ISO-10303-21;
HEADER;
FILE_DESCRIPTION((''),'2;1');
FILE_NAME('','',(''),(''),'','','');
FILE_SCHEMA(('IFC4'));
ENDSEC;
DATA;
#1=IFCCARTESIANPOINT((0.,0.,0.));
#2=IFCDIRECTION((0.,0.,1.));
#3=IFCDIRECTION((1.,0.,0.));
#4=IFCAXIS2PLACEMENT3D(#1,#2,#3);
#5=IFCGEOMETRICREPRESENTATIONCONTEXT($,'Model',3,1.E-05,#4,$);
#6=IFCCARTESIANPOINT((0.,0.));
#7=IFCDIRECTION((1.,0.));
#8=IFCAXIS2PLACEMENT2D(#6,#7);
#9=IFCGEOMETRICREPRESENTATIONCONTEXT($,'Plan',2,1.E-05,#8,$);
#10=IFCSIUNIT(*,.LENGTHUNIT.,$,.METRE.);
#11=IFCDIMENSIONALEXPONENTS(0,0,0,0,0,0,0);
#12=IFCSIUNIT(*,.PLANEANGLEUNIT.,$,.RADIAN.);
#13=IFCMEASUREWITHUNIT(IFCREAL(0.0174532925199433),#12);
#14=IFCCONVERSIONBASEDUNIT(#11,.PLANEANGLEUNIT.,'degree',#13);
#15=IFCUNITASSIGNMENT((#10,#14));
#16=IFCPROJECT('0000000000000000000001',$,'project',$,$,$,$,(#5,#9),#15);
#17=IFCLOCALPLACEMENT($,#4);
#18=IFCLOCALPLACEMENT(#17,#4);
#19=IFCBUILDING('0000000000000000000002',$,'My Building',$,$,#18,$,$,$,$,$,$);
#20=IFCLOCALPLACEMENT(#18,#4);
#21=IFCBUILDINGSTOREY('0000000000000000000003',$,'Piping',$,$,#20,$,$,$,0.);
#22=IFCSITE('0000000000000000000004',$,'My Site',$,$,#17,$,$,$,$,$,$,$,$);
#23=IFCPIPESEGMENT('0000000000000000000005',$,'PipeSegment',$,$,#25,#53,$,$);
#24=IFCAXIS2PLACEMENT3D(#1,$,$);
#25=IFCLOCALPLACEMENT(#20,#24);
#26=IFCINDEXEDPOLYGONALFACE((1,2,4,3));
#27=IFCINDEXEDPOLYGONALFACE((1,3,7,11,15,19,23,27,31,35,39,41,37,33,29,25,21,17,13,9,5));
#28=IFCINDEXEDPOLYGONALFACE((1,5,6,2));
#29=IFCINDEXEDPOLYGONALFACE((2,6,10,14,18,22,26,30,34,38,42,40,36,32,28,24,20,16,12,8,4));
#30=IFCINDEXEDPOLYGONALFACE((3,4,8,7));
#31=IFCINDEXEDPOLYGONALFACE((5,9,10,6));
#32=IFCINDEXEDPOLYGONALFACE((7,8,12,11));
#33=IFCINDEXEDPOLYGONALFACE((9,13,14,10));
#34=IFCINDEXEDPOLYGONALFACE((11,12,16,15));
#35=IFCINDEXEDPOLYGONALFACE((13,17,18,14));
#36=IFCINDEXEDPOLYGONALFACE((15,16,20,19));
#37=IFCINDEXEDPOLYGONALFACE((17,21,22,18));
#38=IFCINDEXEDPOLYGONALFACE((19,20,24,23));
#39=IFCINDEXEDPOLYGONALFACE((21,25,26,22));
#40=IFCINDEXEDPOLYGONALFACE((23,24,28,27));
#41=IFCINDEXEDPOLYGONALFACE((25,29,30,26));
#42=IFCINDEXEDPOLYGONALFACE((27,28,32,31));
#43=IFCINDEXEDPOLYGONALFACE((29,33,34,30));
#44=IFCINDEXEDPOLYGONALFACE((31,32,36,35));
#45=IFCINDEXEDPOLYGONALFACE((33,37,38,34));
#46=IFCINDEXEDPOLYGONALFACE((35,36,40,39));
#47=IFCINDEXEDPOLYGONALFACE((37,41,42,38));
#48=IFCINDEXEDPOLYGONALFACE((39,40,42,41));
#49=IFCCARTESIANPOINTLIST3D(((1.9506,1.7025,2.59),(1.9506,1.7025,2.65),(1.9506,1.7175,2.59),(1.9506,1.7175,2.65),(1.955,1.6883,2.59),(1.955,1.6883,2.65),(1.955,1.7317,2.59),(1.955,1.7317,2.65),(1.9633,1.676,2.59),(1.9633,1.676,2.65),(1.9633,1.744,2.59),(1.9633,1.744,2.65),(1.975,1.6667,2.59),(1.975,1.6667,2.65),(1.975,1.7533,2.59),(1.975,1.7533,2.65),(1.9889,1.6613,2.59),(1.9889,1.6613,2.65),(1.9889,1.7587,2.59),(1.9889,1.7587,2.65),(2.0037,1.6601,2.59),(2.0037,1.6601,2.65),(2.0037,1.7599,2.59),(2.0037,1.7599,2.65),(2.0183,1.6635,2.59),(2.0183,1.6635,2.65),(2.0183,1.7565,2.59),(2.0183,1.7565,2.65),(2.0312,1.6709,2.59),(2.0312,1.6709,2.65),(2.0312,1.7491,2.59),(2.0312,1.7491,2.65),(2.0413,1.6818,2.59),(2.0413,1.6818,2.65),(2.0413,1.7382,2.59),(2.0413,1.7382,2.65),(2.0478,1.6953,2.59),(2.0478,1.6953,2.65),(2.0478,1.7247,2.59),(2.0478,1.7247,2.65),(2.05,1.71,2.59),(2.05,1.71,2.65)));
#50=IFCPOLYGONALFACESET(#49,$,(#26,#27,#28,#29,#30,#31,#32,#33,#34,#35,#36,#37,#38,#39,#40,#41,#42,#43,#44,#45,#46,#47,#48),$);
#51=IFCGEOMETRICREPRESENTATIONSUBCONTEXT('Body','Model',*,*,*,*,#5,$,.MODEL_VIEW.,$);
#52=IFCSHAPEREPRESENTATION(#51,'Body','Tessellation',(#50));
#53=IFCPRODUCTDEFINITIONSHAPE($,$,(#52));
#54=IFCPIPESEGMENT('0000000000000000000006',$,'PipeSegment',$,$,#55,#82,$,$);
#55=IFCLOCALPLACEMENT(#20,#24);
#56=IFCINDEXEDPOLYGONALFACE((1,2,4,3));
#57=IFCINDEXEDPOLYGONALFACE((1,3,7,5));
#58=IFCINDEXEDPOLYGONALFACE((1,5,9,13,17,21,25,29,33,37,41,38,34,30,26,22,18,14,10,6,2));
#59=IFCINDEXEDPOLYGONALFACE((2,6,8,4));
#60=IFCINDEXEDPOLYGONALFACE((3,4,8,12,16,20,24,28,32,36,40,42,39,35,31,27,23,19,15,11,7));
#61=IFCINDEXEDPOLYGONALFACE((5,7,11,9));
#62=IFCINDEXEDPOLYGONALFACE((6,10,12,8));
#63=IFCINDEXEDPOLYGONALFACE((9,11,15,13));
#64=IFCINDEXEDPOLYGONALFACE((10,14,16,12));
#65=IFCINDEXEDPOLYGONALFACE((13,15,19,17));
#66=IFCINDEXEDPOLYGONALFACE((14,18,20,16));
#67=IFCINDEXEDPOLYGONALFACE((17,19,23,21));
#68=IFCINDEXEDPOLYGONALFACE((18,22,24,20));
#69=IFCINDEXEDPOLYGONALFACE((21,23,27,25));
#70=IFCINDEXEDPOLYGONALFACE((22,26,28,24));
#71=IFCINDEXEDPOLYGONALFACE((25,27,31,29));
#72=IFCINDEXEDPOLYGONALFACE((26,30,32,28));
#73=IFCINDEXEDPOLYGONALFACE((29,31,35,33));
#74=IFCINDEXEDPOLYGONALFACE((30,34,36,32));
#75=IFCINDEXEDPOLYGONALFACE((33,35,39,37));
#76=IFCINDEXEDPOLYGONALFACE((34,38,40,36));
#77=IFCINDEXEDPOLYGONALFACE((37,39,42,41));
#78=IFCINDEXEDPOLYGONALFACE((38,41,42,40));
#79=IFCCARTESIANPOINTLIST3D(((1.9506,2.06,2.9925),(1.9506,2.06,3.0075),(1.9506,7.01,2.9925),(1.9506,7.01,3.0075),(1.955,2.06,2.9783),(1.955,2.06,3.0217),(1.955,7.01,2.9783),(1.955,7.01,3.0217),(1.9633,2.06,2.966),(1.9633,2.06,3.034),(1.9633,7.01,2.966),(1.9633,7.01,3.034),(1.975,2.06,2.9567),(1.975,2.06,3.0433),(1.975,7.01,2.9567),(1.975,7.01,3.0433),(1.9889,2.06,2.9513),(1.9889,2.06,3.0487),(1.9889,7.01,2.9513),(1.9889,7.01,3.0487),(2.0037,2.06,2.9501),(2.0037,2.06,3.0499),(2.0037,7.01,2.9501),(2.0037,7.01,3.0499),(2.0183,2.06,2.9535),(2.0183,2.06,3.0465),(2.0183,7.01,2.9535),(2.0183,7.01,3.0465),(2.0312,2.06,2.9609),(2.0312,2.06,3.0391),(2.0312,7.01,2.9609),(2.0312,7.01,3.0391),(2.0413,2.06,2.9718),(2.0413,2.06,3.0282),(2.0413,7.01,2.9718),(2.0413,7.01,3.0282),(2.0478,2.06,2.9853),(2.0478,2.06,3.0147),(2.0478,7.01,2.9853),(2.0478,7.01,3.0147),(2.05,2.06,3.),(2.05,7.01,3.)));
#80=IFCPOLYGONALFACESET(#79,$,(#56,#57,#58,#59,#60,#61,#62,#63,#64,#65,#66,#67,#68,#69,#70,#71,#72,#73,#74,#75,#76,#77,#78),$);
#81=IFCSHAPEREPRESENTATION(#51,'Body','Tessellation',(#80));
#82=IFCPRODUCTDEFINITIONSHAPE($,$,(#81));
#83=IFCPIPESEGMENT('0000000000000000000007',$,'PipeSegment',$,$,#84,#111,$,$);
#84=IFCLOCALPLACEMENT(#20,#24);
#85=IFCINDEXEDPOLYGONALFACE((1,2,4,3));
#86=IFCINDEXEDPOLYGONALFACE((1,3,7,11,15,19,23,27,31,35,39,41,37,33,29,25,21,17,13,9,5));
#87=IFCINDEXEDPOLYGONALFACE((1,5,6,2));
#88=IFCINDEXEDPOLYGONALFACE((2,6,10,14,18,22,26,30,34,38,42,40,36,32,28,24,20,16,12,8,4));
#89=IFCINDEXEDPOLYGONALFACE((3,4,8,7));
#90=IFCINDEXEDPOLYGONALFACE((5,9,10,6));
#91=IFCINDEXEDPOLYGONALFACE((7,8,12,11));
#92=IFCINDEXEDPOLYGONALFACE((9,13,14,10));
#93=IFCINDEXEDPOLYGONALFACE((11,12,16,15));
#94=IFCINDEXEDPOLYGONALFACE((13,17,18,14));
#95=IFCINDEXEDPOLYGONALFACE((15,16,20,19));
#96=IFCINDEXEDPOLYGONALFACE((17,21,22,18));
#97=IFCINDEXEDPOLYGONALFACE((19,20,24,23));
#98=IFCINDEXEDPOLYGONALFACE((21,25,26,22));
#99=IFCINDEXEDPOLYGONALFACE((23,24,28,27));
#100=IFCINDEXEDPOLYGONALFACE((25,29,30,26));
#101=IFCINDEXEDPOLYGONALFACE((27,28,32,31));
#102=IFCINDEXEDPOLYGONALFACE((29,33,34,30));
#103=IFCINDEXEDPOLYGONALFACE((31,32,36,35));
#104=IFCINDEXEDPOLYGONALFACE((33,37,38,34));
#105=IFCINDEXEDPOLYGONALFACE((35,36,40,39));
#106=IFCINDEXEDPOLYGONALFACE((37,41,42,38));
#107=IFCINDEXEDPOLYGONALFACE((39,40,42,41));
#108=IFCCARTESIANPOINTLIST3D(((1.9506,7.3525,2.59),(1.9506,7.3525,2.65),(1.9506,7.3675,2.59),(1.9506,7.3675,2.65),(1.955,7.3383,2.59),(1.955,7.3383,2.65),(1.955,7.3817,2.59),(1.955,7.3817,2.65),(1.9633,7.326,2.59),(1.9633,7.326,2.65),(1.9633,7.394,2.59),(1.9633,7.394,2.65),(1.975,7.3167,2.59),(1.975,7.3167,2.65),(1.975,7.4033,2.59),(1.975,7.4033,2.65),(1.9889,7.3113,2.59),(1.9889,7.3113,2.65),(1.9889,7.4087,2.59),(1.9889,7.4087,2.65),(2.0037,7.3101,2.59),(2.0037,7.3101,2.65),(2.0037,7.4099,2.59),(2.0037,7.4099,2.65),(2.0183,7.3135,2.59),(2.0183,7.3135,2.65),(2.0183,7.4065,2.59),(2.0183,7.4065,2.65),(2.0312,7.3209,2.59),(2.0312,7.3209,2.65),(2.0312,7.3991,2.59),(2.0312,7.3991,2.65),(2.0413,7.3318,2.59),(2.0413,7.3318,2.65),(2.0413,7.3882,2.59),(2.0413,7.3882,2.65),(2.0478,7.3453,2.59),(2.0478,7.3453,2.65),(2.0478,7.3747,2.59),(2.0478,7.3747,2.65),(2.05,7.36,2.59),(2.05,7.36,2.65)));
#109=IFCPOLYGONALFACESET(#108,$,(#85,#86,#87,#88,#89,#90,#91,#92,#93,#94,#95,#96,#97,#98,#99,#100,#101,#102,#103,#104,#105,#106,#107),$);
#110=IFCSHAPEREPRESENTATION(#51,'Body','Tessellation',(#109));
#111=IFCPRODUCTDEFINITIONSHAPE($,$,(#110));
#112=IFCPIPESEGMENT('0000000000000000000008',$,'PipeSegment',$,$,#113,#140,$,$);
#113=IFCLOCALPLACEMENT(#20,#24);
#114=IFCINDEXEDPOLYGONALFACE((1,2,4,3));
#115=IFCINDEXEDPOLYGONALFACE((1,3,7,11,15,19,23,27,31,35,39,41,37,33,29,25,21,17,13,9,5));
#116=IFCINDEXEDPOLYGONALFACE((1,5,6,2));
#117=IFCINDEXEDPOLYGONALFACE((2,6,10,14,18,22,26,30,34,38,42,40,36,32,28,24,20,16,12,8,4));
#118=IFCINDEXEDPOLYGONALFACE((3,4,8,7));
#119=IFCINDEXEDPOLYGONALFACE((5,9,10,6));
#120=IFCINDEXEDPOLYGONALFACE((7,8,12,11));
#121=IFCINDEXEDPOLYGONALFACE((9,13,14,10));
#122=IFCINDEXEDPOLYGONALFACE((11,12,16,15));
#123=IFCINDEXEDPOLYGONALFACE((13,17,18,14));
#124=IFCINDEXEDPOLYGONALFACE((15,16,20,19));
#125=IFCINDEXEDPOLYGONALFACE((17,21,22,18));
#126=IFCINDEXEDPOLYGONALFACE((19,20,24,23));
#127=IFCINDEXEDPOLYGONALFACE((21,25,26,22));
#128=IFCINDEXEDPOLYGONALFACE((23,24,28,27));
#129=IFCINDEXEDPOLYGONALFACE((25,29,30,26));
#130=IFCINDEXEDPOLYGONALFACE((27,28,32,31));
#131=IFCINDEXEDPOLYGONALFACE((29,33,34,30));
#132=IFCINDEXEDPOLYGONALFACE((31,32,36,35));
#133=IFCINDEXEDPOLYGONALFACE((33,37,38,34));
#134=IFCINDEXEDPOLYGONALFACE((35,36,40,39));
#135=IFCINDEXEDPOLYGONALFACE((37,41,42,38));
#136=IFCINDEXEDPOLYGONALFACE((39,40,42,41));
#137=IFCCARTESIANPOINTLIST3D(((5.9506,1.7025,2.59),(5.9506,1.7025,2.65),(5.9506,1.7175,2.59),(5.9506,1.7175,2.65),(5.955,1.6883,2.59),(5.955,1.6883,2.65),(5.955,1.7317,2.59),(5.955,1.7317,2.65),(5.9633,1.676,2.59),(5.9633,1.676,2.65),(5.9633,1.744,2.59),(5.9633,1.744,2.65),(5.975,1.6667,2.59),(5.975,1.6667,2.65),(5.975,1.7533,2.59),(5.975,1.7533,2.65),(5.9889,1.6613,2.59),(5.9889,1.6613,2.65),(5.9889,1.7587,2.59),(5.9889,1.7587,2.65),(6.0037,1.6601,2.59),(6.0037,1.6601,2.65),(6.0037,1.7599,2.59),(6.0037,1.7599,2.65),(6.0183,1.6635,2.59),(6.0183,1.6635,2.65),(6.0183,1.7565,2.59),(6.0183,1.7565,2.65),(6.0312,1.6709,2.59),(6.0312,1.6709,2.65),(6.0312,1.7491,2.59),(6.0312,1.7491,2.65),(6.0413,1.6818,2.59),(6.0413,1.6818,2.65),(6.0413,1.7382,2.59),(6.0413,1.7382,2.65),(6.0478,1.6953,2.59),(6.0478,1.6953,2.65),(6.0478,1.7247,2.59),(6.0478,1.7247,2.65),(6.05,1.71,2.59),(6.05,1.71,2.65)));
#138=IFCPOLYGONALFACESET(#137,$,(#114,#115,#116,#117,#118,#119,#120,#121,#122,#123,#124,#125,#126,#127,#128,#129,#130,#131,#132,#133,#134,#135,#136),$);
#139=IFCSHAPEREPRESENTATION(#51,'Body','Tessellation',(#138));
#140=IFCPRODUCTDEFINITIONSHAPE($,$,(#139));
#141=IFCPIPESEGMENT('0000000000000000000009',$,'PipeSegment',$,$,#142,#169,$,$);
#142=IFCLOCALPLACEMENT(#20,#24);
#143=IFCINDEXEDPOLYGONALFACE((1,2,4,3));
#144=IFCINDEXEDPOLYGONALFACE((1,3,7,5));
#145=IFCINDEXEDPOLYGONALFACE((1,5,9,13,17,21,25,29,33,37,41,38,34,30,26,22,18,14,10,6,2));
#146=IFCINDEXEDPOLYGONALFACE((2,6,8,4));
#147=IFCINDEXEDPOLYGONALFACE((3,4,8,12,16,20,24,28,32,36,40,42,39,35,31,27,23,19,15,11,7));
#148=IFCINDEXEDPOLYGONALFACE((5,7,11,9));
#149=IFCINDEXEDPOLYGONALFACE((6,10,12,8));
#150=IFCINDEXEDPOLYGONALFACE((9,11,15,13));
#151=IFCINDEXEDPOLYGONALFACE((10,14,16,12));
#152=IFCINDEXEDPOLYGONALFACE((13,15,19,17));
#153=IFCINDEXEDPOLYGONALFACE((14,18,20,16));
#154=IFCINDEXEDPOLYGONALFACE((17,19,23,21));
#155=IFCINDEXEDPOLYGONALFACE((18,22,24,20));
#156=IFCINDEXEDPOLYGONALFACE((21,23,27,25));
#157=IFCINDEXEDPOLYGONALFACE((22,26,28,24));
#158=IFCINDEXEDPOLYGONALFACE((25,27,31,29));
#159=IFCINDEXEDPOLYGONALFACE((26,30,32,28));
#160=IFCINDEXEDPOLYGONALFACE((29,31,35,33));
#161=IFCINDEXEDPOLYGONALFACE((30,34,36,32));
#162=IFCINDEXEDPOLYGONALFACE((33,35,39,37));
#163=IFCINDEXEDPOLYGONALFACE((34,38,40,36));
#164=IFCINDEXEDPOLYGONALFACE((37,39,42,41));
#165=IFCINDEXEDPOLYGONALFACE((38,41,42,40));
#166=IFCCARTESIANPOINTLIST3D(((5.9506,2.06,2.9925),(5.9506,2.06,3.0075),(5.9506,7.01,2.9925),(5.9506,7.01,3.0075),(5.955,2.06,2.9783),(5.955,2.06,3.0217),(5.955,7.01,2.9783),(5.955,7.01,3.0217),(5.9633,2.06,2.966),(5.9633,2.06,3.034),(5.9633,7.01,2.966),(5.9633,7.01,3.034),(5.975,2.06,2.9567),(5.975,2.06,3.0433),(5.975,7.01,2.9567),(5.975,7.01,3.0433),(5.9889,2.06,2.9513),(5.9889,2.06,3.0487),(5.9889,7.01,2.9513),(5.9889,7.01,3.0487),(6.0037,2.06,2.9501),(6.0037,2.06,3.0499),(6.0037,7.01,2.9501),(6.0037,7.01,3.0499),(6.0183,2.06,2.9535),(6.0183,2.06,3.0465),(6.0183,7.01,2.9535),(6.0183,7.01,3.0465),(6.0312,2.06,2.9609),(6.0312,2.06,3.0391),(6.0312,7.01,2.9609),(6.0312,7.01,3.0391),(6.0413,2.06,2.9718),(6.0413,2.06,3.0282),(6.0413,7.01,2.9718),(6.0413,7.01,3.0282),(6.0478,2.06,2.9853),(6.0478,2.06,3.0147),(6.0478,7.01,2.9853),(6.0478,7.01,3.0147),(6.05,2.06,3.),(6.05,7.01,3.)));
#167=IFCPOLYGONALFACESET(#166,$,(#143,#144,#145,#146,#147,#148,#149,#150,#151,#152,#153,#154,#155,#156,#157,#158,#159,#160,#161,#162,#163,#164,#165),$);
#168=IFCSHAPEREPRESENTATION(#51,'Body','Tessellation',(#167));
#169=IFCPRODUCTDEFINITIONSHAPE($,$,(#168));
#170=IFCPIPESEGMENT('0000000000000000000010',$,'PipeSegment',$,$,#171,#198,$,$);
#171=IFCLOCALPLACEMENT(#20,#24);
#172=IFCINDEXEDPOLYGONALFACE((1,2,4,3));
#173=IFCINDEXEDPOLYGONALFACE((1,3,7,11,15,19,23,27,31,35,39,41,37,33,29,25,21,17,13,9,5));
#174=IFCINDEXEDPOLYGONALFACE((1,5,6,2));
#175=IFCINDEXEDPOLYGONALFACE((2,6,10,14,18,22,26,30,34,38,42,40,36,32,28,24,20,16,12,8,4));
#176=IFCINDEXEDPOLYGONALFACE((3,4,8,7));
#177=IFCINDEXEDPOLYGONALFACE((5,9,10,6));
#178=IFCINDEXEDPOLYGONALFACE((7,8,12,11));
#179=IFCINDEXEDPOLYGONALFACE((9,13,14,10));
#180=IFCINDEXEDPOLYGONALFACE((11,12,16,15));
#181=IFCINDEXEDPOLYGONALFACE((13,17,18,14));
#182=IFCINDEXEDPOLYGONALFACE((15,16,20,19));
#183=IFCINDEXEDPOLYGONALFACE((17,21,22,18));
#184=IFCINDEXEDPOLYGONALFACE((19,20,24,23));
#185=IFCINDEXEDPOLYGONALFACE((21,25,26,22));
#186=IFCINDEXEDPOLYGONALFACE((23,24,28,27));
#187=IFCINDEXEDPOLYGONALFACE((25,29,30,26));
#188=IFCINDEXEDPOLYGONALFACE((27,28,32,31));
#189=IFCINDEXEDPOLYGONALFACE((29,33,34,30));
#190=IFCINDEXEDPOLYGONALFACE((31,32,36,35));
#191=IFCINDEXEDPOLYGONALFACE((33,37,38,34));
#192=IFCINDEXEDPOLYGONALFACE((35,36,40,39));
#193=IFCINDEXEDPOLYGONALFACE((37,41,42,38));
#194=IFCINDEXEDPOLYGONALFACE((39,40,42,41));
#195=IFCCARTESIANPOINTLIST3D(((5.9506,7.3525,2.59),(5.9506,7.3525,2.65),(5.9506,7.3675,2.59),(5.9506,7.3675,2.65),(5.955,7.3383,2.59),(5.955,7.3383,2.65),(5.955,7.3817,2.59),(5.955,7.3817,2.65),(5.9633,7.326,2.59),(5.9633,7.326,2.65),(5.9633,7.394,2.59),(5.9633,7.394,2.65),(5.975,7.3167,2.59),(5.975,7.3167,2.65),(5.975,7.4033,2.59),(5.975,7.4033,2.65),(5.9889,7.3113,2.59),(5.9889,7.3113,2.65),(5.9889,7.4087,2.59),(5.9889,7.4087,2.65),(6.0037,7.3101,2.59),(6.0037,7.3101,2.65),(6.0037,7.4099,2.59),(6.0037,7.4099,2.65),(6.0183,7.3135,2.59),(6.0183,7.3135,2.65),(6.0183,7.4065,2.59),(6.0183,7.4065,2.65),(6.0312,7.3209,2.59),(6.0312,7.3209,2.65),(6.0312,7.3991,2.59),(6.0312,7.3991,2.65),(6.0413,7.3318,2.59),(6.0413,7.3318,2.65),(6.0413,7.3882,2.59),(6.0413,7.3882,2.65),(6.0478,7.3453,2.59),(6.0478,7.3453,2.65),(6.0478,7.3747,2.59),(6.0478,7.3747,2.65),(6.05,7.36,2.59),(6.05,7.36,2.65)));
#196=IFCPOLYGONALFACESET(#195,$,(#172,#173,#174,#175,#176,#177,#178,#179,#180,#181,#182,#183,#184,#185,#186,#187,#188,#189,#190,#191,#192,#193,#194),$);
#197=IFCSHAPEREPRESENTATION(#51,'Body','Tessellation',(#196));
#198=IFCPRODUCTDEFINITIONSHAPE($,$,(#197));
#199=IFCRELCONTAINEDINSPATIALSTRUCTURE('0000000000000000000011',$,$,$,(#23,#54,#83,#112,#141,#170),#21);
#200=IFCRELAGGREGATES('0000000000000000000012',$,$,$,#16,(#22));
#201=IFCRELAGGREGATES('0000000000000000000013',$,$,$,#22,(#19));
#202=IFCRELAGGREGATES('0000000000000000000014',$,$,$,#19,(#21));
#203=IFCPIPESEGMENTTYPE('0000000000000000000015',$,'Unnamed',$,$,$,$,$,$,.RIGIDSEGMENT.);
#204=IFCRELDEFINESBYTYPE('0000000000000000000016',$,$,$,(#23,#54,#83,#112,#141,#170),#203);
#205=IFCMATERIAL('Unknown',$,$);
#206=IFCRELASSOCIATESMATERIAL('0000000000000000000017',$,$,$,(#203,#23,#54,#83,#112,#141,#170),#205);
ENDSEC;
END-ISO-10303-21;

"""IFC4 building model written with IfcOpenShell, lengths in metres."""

from ifc_helpers import new_model, entity, si_unit, converted_unit, frame, origin_with_axes, origin_2d_with_axis, place, context, subcontext, project, spatial, circle, extrude, material, material_profile, profile_set, profile_usage, type_object, element, save


model = new_model("IFC4")

# Units and contexts
model_context = context("Model", 3, precision=1e-05, world=origin_with_axes())
plan_context = context("Plan", 2, precision=1e-05, world=origin_2d_with_axis())
body_context = subcontext(model_context, "Body", "Model", "MODEL_VIEW")
ifc_project = project(units=[si_unit("LENGTHUNIT", "METRE"), converted_unit("PLANEANGLEUNIT", "degree", entity("IfcReal", 0.0174532925199433), si_unit("PLANEANGLEUNIT", "RADIAN"), dimensions=[0, 0, 0, 0, 0, 0, 0])], contexts=[model_context, plan_context])

# Site, building, storey
site_placement = place(None, origin_with_axes())
site = spatial("IfcSite", under=ifc_project, at=site_placement, Name="My Site")
building_placement = place(site_placement, origin_with_axes())
building = spatial("IfcBuilding", under=site, at=building_placement, Name="My Building")
storey_placement = place(building_placement, origin_with_axes())
storey = spatial("IfcBuildingStorey", under=building, at=storey_placement, Name="Piping", Elevation=0.0)

# Pipe segments
ifc_material = material(Name="Unknown")
ifc_material_profile = material_profile(ifc_material, circle(Radius=0.05))
ifc_profile_set = profile_set([ifc_material_profile])
ifc_profile_usage_1 = profile_usage(ifc_profile_set)
pipe_segment_type = type_object("IfcPipeSegmentType", Name="Unnamed", PredefinedType="RIGIDSEGMENT", material=ifc_profile_set)
pipe_segment_1_placement = place(storey_placement, frame((2.0, 1.71, 2.59), z_axis=(0.0, 0.0, 1.0), x_axis=(1.0, 0.0, 0.0)))
element("IfcPipeSegment", 1, at=pipe_segment_1_placement, inside=storey, type_object=pipe_segment_type, material=ifc_profile_usage_1, Name="PipeSegment", context=body_context, shape_type="SweptSolid", body=[
    extrude(circle(Radius=0.05), origin_with_axes(), (0.0, 0.0, 1.0), 0.06),
])
ifc_profile_usage_2 = profile_usage(ifc_profile_set)
pipe_segment_2_placement = place(storey_placement, frame((2.0, 2.06, 3.0), z_axis=(0.0, 1.0, 0.0), x_axis=(1.0, 0.0, 0.0)))
element("IfcPipeSegment", 2, at=pipe_segment_2_placement, inside=storey, type_object=pipe_segment_type, material=ifc_profile_usage_2, Name="PipeSegment", context=body_context, shape_type="SweptSolid", body=[
    extrude(circle(Radius=0.05), origin_with_axes(), (0.0, 0.0, 1.0), 4.95),
])
ifc_profile_usage_3 = profile_usage(ifc_profile_set)
pipe_segment_3_placement = place(storey_placement, frame((2.0, 7.36, 2.65), z_axis=(0.0, 0.0, -1.0), x_axis=(1.0, 0.0, 0.0)))
element("IfcPipeSegment", 3, at=pipe_segment_3_placement, inside=storey, type_object=pipe_segment_type, material=ifc_profile_usage_3, Name="PipeSegment", context=body_context, shape_type="SweptSolid", body=[
    extrude(circle(Radius=0.05), origin_with_axes(), (0.0, 0.0, 1.0), 0.06),
])
ifc_profile_usage_4 = profile_usage(ifc_profile_set)
pipe_segment_4_placement = place(storey_placement, frame((6.0, 1.71, 2.59), z_axis=(0.0, 0.0, 1.0), x_axis=(1.0, 0.0, 0.0)))
element("IfcPipeSegment", 4, at=pipe_segment_4_placement, inside=storey, type_object=pipe_segment_type, material=ifc_profile_usage_4, Name="PipeSegment", context=body_context, shape_type="SweptSolid", body=[
    extrude(circle(Radius=0.05), origin_with_axes(), (0.0, 0.0, 1.0), 0.06),
])
ifc_profile_usage_5 = profile_usage(ifc_profile_set)
pipe_segment_5_placement = place(storey_placement, frame((6.0, 2.06, 3.0), z_axis=(0.0, 1.0, 0.0), x_axis=(1.0, 0.0, 0.0)))
element("IfcPipeSegment", 5, at=pipe_segment_5_placement, inside=storey, type_object=pipe_segment_type, material=ifc_profile_usage_5, Name="PipeSegment", context=body_context, shape_type="SweptSolid", body=[
    extrude(circle(Radius=0.05), origin_with_axes(), (0.0, 0.0, 1.0), 4.95),
])
ifc_profile_usage_6 = profile_usage(ifc_profile_set)
pipe_segment_6_placement = place(storey_placement, frame((6.0, 7.36, 2.65), z_axis=(0.0, 0.0, -1.0), x_axis=(1.0, 0.0, 0.0)))
element("IfcPipeSegment", 6, at=pipe_segment_6_placement, inside=storey, type_object=pipe_segment_type, material=ifc_profile_usage_6, Name="PipeSegment", context=body_context, shape_type="SweptSolid", body=[
    extrude(circle(Radius=0.05), origin_with_axes(), (0.0, 0.0, 1.0), 0.06),
])

save(model, "model.ifc")
